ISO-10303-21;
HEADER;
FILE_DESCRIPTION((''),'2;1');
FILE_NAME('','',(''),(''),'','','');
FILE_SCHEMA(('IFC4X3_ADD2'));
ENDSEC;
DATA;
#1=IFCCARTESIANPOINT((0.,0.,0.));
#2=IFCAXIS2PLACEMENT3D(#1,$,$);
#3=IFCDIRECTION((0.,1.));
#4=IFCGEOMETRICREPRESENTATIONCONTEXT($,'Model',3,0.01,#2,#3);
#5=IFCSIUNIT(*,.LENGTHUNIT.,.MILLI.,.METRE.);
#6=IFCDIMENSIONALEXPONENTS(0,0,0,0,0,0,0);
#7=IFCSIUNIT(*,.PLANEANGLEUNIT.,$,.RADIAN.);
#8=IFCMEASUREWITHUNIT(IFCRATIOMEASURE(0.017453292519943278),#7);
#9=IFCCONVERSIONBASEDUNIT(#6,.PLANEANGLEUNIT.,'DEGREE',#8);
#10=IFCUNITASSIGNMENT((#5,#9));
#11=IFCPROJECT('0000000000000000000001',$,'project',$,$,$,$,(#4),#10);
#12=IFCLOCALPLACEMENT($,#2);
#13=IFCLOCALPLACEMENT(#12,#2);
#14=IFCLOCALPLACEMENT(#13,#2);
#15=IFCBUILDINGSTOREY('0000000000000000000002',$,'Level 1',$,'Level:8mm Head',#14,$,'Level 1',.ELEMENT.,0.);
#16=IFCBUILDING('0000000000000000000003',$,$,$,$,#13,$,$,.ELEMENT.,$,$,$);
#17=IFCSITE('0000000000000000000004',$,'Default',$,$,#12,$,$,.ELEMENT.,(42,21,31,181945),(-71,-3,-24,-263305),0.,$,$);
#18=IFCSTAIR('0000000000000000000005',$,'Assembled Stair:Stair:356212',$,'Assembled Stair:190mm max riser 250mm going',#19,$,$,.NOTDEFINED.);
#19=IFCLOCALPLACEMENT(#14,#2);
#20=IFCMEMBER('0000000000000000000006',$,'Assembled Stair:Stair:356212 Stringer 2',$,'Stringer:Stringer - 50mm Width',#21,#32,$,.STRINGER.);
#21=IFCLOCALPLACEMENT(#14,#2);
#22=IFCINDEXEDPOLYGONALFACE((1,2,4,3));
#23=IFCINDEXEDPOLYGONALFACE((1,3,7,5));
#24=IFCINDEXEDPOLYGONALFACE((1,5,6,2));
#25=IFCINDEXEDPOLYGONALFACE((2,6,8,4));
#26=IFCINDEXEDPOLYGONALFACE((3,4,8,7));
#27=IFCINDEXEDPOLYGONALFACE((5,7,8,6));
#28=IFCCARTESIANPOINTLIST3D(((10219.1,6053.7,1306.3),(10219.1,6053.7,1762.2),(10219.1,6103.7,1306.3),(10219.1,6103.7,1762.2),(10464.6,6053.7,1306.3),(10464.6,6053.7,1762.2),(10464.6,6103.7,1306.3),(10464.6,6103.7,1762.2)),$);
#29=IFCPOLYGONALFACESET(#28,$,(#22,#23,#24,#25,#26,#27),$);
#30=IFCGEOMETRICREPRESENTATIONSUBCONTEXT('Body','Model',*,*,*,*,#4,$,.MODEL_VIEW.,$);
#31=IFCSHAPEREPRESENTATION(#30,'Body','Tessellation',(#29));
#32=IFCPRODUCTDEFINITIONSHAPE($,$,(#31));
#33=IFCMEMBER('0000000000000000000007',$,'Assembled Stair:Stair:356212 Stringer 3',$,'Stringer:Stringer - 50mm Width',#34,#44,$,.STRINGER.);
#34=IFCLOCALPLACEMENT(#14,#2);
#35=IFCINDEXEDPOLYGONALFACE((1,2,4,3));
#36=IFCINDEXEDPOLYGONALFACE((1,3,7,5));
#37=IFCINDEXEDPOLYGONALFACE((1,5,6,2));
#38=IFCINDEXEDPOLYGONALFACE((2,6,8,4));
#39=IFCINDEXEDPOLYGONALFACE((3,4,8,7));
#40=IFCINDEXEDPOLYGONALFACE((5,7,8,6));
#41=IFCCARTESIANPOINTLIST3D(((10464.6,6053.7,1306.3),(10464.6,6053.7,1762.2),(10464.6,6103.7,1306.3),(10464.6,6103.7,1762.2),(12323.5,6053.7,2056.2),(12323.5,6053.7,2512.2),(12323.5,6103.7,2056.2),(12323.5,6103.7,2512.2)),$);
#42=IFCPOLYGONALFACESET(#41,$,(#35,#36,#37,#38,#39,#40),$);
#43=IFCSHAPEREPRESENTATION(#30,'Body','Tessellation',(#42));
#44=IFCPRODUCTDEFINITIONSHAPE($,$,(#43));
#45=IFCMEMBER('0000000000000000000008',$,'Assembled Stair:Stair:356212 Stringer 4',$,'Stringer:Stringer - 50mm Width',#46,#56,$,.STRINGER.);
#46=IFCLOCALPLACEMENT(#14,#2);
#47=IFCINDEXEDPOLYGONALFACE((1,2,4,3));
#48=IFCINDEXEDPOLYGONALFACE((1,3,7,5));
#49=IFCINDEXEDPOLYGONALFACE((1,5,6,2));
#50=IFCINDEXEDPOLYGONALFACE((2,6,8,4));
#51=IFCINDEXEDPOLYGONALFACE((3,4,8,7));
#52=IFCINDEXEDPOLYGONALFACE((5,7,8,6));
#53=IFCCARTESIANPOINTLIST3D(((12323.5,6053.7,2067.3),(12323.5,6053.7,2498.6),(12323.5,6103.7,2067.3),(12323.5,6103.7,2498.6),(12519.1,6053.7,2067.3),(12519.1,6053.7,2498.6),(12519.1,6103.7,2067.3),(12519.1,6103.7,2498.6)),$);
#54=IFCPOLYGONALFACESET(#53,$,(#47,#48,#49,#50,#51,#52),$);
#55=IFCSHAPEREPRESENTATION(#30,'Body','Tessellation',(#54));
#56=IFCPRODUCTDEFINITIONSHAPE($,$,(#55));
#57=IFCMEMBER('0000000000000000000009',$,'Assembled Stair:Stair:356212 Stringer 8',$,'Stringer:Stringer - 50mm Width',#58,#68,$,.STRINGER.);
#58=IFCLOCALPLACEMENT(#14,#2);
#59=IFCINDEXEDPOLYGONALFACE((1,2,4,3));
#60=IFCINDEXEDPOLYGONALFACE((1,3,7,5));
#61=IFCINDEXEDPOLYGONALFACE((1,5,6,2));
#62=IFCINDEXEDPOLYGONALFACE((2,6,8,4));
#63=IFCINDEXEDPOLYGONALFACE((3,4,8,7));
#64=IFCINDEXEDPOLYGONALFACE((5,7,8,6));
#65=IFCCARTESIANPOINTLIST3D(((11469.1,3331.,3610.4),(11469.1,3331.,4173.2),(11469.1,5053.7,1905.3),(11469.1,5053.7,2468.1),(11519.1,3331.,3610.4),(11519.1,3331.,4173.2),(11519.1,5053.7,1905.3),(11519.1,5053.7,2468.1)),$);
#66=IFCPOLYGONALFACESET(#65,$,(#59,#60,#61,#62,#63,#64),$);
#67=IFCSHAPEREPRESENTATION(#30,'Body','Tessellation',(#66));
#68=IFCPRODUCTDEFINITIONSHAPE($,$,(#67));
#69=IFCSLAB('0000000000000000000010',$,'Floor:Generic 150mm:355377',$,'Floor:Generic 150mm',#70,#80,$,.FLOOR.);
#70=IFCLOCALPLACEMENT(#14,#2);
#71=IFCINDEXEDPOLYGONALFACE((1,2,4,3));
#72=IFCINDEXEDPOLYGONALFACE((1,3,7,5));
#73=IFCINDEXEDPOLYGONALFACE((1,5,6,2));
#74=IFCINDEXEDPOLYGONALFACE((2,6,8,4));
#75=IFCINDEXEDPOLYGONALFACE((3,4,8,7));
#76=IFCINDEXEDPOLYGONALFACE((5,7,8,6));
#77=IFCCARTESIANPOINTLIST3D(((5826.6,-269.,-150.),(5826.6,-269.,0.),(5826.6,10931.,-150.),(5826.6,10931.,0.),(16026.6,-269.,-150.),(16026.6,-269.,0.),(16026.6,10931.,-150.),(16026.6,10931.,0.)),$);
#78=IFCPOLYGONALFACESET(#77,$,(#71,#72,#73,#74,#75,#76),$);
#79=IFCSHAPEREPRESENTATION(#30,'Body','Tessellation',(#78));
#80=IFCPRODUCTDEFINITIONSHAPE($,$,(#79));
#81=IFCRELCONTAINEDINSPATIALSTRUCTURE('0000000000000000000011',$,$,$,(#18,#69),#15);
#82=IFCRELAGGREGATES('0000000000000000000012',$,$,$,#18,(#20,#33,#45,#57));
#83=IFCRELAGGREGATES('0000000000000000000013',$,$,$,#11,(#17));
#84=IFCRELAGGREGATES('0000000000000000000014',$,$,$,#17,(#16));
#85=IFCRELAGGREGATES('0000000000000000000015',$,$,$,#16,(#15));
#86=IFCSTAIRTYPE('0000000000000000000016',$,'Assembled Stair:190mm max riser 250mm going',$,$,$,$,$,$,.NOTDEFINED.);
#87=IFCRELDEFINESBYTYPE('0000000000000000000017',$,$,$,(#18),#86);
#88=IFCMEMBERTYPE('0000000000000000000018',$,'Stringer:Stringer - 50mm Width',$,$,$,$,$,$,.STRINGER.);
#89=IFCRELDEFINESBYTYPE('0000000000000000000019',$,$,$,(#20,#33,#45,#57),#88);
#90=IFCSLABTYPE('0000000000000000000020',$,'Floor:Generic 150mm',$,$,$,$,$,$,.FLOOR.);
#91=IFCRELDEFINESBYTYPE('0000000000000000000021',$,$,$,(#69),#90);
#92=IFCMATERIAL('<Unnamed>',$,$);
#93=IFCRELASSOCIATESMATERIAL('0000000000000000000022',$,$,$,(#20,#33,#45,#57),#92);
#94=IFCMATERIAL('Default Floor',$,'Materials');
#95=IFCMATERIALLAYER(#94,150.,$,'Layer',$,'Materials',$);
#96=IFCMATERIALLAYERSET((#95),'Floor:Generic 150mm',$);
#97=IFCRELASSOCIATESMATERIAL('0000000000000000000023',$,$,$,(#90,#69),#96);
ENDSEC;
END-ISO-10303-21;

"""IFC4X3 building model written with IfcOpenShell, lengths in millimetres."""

from ifc_helpers import new_model, entity, si_unit, converted_unit, direction, frame, frame_2d, origin, place, context, subcontext, project, spatial, polyline, rectangle, outline, extrude, material, layer, layer_set, layer_usage, type_object, element, aggregate, save


model = new_model("IFC4X3")

# Units and contexts
model_context = context("Model", 3, precision=0.01, world=origin(), true_north=direction((0.0, 1.0)))
body_context = subcontext(model_context, "Body", "Model", "MODEL_VIEW")
ifc_project = project(units=[si_unit("LENGTHUNIT", "METRE", prefix="MILLI"), converted_unit("PLANEANGLEUNIT", "DEGREE", entity("IfcRatioMeasure", 0.017453292519943278), si_unit("PLANEANGLEUNIT", "RADIAN"), dimensions=[0, 0, 0, 0, 0, 0, 0])], contexts=[model_context])

# Site, building, storey
site_placement = place(None, origin())
site = spatial("IfcSite", under=ifc_project, at=site_placement, Name="Default", CompositionType="ELEMENT", RefLatitude=(42, 21, 31, 181945), RefLongitude=(-71, -3, -24, -263305), RefElevation=0.0)
building_placement = place(site_placement, origin())
building = spatial("IfcBuilding", under=site, at=building_placement, CompositionType="ELEMENT")
storey_placement = place(building_placement, origin())
storey = spatial("IfcBuildingStorey", under=building, at=storey_placement, Name="Level 1", ObjectType="Level:8mm Head", LongName="Level 1", CompositionType="ELEMENT", Elevation=0.0)

# Stair, members
stair_type = type_object("IfcStairType", Name="Assembled Stair:190mm max riser 250mm going", PredefinedType="NOTDEFINED")
stair_placement = place(storey_placement, origin())
stair = element("IfcStair", 1, at=stair_placement, inside=storey, type_object=stair_type, Name="Assembled Stair:Stair:356212", ObjectType="Assembled Stair:190mm max riser 250mm going", PredefinedType="NOTDEFINED")
ifc_material_1 = material(Name="<Unnamed>")
member_type = type_object("IfcMemberType", Name="Stringer:Stringer - 50mm Width", PredefinedType="STRINGER")
member_1_placement = place(stair_placement, frame((10219.1, 6053.7, 1306.3)))
member_1 = element("IfcMember", 2, at=member_1_placement, type_object=member_type, material=ifc_material_1, Name="Assembled Stair:Stair:356212 Stringer 2", ObjectType="Stringer:Stringer - 50mm Width", PredefinedType="STRINGER", context=body_context, shape_type="SweptSolid", body=[
    extrude(rectangle(XDim=245.5, YDim=50.0, at=frame_2d((0.0, 0.0), x_axis=(1.0, 0.0))), frame((122.8, 25.0, 0.0)), (0.0, 0.0, 1.0), 455.9),
])
member_2_placement = place(stair_placement, frame((10464.6, 6053.7, 1306.3)))
member_2 = element("IfcMember", 3, at=member_2_placement, type_object=member_type, material=ifc_material_1, Name="Assembled Stair:Stair:356212 Stringer 3", ObjectType="Stringer:Stringer - 50mm Width", PredefinedType="STRINGER", context=body_context, shape_type="SweptSolid", body=[
    extrude(outline(polyline([(-917.0, -211.4), (1087.5, -211.4), (917.0, 211.4), (-1087.5, 211.4), (-917.0, -211.4)])), frame((929.5, 0.0, 602.9), z_axis=(0.0, 1.0, 0.0), x_axis=(0.927382, 0.0, 0.374115)), (0.0, 0.0, 1.0), 50.0),
])
member_3_placement = place(stair_placement, frame((12323.5, 6053.7, 2067.3)))
member_3 = element("IfcMember", 4, at=member_3_placement, type_object=member_type, material=ifc_material_1, Name="Assembled Stair:Stair:356212 Stringer 4", ObjectType="Stringer:Stringer - 50mm Width", PredefinedType="STRINGER", context=body_context, shape_type="SweptSolid", body=[
    extrude(rectangle(XDim=195.5, YDim=50.0, at=frame_2d((0.0, 0.0), x_axis=(1.0, 0.0))), frame((97.8, 25.0, 0.0)), (0.0, 0.0, 1.0), 431.3),
])
member_4_placement = place(stair_placement, frame((11469.1, 3331.0, 1905.3)))
member_4 = element("IfcMember", 5, at=member_4_placement, type_object=member_type, material=ifc_material_1, Name="Assembled Stair:Stair:356212 Stringer 8", ObjectType="Stringer:Stringer - 50mm Width", PredefinedType="STRINGER", context=body_context, shape_type="SweptSolid", body=[
    extrude(outline(polyline([(-1014.0, -200.0), (1409.9, -200.0), (1014.0, 200.0), (-1409.9, 200.0), (-1014.0, -200.0)])), frame((0.0, 861.3, 1134.0), z_axis=(1.0, 0.0, 0.0), x_axis=(0.0, -0.710714, 0.703481)), (0.0, 0.0, 1.0), 50.0),
])

# Slab
ifc_material_2 = material(Name="Default Floor", Category="Materials")
ifc_layer_1 = layer(ifc_material_2, 150.0, Name="Layer", Category="Materials")
ifc_layer_set_1 = layer_set([ifc_layer_1], Name="Floor:Generic 150mm")
ifc_layer_usage_1 = layer_usage(ifc_layer_set_1, "AXIS3", "POSITIVE", 0.0)
slab_type = type_object("IfcSlabType", Name="Floor:Generic 150mm", PredefinedType="FLOOR", material=ifc_layer_set_1)
slab_placement = place(storey_placement, origin())
element("IfcSlab", 6, at=slab_placement, inside=storey, type_object=slab_type, material=ifc_layer_usage_1, Name="Floor:Generic 150mm:355377", ObjectType="Floor:Generic 150mm", PredefinedType="FLOOR", context=body_context, shape_type="SweptSolid", body=[
    extrude(rectangle(XDim=11200.0, YDim=10200.0, at=frame_2d((0.0, 0.0), x_axis=(1.0, 0.0))), frame((10926.6, 5331.0, 0.0), z_axis=(0.0, 0.0, -1.0), x_axis=(0.0, 1.0, 0.0)), (0.0, 0.0, 1.0), 150.0),
])

aggregate(stair, [member_1, member_2, member_3, member_4])

save(model, "model.ifc")
